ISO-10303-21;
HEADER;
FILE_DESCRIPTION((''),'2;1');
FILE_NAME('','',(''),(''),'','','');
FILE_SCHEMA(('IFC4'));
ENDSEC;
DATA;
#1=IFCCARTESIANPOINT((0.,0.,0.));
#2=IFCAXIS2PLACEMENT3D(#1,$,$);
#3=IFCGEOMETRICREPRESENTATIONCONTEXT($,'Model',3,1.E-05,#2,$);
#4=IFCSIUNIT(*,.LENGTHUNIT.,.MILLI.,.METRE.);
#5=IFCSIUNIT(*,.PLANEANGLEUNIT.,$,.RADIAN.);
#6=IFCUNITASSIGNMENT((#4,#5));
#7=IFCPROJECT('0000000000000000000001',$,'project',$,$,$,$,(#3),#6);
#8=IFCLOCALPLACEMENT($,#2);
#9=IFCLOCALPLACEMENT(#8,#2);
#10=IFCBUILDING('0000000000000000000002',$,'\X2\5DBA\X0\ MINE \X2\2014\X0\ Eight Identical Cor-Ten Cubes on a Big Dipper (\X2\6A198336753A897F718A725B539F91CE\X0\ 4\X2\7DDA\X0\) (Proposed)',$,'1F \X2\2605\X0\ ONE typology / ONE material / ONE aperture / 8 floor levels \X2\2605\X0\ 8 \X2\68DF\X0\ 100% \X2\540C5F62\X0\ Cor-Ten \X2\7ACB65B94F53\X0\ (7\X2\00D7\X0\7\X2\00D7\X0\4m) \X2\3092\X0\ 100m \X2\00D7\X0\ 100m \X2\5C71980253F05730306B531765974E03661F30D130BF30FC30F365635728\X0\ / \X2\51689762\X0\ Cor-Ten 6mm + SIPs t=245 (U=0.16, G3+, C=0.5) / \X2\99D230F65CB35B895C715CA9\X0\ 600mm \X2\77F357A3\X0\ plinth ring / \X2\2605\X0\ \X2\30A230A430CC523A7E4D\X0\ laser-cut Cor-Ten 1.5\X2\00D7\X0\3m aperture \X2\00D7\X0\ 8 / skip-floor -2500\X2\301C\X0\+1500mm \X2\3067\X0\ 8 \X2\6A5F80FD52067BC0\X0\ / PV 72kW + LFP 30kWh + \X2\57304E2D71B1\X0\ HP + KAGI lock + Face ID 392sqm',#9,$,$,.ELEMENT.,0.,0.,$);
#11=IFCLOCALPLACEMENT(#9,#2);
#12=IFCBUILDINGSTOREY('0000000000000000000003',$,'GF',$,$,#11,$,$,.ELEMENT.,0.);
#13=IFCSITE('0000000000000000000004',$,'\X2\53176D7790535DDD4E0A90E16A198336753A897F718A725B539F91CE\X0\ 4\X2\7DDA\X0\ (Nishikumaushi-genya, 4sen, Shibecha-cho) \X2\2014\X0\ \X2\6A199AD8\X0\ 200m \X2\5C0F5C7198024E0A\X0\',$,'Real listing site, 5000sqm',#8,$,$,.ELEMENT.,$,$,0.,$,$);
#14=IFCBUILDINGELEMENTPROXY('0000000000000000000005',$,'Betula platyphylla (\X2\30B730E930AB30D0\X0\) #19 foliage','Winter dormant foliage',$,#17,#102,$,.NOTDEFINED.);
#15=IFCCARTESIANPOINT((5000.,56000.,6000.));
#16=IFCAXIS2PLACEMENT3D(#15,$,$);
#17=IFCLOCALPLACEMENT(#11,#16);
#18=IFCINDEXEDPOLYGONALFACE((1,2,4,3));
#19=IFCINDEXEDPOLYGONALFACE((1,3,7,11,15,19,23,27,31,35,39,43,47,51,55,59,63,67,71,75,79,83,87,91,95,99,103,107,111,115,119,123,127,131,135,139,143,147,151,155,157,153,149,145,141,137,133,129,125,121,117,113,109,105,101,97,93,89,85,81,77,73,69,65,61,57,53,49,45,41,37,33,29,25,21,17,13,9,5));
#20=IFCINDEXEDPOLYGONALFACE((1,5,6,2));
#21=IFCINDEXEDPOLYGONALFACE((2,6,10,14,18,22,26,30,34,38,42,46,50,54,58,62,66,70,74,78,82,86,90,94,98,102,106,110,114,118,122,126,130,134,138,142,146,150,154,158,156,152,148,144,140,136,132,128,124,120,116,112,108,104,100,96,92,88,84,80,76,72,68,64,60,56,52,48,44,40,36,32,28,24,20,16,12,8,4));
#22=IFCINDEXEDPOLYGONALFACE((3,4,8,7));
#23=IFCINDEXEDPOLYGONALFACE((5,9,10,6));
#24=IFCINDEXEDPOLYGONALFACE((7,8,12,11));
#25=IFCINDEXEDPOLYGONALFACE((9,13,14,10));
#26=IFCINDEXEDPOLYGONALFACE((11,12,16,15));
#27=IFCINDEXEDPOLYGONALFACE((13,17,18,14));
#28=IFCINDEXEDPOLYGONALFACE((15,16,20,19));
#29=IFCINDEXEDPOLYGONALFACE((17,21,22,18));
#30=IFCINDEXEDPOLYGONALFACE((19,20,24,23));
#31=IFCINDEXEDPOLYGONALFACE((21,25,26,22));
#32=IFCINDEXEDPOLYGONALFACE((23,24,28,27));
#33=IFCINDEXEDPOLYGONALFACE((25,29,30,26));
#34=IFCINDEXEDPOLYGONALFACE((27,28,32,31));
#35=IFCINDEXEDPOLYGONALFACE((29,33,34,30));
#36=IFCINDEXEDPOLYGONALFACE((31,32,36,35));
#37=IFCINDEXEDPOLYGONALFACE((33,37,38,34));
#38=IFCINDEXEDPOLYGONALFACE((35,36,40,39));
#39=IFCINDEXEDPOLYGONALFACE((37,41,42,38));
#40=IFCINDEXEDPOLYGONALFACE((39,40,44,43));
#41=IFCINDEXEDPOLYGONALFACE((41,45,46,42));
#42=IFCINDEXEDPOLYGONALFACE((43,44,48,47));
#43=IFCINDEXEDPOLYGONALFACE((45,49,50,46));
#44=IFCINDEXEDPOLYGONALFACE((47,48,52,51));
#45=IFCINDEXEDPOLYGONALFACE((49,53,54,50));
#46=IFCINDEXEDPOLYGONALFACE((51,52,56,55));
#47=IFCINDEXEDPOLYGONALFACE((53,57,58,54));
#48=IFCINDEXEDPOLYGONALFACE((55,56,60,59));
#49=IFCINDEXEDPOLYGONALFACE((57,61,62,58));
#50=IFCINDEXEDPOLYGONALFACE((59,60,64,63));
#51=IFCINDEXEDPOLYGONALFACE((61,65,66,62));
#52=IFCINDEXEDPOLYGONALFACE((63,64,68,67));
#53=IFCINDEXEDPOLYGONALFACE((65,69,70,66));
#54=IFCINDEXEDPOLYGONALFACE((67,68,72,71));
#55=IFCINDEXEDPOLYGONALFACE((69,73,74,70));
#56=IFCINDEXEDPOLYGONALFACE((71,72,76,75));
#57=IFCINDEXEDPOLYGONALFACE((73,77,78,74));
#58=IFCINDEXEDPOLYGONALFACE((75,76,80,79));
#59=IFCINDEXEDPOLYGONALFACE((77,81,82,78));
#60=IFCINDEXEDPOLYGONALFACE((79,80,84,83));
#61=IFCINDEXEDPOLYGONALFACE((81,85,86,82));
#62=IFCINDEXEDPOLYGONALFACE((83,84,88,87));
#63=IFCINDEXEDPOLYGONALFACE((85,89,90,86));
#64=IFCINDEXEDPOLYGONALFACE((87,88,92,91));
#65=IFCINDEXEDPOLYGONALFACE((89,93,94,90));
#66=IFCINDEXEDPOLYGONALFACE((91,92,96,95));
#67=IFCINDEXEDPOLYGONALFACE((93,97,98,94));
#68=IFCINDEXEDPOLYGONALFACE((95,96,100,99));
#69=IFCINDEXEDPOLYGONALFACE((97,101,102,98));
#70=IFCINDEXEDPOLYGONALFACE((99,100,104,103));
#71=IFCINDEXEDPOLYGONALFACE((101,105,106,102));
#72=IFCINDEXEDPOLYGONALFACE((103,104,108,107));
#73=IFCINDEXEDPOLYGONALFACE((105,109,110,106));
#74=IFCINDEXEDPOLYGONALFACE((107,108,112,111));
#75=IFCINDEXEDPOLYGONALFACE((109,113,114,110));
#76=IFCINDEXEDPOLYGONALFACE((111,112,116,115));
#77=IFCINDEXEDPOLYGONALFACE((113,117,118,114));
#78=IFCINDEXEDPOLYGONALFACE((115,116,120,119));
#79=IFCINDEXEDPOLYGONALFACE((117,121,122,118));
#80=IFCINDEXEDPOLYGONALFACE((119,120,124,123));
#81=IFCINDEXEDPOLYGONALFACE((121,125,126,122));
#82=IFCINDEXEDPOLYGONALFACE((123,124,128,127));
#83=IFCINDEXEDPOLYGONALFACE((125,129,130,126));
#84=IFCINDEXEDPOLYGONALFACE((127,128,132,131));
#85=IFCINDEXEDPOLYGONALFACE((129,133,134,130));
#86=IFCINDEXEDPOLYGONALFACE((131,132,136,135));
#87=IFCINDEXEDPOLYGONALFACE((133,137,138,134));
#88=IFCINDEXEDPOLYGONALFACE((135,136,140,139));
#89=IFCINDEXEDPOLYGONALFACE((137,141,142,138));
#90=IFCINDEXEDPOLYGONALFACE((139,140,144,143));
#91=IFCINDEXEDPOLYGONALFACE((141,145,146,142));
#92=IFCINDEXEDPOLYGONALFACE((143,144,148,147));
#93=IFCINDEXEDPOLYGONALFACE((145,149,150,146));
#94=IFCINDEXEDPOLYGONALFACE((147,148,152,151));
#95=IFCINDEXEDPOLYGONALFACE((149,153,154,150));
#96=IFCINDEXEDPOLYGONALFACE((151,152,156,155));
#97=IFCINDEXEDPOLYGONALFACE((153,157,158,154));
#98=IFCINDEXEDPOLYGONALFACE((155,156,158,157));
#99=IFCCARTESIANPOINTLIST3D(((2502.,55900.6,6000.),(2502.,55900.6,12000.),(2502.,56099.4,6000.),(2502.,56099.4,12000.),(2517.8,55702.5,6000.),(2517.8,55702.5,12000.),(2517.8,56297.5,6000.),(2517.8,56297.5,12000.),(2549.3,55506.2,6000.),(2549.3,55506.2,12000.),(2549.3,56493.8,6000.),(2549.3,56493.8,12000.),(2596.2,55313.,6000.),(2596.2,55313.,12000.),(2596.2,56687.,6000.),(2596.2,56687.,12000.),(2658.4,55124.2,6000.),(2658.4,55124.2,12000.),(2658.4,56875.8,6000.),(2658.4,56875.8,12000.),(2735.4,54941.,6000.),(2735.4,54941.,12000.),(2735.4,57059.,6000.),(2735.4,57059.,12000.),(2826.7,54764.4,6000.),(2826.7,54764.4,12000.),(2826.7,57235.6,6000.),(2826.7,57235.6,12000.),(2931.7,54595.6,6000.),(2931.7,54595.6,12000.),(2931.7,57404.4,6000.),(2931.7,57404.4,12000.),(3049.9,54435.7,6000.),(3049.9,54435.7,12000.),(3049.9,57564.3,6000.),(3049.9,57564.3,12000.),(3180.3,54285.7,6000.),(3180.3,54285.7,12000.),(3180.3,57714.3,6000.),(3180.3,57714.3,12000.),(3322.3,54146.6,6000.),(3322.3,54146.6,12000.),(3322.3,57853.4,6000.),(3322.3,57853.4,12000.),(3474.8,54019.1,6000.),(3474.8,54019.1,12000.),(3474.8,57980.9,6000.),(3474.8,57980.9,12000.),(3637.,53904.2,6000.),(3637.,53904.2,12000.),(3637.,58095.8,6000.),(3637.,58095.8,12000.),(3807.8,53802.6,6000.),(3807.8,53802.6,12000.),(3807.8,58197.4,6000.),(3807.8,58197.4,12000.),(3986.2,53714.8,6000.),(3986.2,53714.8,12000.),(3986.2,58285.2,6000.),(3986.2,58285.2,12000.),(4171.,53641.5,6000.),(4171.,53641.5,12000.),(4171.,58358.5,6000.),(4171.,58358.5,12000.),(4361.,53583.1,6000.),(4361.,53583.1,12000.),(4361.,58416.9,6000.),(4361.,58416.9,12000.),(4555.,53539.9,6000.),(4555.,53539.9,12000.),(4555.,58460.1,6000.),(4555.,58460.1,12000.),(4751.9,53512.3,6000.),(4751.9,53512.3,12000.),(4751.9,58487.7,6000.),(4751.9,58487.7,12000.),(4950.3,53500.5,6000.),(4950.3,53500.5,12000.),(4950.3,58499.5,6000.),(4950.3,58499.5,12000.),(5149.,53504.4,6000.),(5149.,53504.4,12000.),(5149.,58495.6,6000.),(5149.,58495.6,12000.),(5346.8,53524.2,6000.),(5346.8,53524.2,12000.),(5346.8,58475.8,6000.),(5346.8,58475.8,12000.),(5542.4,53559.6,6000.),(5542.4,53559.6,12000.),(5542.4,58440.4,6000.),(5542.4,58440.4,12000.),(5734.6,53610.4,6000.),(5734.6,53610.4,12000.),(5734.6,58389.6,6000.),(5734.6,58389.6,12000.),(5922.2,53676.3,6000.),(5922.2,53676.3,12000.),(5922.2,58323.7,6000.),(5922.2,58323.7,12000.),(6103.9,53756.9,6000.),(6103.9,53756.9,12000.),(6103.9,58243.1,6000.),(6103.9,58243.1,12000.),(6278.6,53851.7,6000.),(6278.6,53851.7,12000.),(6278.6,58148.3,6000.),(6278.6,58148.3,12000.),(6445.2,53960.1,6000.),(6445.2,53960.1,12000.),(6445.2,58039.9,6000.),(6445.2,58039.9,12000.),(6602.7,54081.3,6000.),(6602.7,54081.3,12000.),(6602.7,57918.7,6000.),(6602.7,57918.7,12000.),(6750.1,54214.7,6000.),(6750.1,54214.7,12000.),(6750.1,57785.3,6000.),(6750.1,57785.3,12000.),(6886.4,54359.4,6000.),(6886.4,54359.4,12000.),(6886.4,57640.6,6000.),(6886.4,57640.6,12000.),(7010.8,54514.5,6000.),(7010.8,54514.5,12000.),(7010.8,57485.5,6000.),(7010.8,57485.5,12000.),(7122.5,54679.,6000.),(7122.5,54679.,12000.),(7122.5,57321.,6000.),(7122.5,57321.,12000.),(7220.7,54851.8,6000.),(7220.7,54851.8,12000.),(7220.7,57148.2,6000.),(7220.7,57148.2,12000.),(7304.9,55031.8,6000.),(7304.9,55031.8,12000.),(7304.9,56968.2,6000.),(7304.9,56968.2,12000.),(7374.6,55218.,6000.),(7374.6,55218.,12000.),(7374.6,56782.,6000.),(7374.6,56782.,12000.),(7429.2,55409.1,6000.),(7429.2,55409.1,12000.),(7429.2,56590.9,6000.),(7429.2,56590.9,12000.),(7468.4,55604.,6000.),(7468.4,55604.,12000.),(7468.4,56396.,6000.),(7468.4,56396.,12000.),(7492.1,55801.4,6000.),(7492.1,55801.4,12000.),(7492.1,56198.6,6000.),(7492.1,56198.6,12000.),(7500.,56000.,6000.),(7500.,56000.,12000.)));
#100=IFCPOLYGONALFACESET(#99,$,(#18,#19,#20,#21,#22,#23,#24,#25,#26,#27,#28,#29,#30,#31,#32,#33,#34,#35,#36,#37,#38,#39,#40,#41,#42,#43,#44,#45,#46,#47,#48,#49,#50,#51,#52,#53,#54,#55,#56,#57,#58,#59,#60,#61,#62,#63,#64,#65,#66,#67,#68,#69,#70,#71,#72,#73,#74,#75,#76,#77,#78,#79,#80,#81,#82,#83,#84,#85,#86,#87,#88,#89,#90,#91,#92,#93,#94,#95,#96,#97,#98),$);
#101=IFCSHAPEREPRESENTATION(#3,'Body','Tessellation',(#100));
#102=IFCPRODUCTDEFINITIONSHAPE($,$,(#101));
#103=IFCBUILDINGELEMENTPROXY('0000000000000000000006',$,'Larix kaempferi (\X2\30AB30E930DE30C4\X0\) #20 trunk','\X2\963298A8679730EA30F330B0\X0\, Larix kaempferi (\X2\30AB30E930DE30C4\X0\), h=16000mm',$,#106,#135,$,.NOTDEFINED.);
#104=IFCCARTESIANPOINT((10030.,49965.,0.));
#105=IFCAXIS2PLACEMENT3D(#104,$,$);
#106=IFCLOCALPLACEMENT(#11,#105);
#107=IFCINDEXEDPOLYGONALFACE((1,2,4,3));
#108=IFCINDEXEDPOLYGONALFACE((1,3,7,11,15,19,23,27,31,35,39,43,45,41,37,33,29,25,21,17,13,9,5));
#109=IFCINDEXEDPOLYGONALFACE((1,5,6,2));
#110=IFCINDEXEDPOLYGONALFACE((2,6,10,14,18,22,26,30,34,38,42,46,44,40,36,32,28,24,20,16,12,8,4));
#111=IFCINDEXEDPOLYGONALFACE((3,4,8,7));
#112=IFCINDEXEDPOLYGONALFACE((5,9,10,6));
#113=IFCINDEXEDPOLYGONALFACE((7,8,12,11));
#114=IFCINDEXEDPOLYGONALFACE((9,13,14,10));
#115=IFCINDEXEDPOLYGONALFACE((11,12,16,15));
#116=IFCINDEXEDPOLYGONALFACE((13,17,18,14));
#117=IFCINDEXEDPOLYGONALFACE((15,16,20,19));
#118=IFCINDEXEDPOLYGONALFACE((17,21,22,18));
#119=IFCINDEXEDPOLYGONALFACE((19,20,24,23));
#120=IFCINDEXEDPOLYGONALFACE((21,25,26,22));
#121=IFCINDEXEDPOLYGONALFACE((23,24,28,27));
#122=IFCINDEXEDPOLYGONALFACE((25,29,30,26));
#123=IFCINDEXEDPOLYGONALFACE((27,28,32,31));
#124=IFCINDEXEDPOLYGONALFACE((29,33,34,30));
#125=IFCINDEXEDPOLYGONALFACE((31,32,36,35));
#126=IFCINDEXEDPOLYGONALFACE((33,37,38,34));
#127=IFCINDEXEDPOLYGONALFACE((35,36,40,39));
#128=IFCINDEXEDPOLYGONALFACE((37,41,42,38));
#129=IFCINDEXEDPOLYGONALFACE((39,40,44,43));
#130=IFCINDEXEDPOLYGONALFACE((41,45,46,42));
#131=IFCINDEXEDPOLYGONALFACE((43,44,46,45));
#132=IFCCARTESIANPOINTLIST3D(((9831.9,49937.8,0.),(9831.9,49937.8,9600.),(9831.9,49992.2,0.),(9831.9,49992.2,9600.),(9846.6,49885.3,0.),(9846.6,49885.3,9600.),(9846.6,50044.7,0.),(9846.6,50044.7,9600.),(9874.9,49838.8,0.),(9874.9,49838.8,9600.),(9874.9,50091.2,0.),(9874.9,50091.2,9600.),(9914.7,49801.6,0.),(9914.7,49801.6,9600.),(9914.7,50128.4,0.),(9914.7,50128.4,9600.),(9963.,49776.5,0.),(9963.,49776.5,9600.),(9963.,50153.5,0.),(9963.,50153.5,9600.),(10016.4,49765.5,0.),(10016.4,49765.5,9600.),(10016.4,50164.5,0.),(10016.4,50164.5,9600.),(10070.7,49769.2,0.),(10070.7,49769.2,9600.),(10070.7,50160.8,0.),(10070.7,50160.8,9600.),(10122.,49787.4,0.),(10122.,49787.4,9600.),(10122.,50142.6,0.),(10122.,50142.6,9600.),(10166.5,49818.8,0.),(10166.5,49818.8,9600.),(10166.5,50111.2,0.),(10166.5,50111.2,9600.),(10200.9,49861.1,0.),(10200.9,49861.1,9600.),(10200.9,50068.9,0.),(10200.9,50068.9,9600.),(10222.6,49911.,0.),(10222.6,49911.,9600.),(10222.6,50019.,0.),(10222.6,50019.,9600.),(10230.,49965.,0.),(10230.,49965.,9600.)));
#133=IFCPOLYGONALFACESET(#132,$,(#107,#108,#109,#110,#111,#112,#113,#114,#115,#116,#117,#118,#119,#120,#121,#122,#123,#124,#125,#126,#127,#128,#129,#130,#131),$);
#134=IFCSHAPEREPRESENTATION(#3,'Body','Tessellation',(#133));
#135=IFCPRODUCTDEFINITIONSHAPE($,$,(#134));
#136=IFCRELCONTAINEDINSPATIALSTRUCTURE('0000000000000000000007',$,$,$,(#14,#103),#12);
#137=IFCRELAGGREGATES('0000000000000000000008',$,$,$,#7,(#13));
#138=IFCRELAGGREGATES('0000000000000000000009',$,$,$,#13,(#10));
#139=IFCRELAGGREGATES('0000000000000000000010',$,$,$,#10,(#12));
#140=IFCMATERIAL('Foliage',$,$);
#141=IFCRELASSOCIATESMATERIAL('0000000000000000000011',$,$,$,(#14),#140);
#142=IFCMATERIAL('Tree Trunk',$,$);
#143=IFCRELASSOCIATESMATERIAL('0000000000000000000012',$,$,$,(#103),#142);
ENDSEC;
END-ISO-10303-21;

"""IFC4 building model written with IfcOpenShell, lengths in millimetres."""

from ifc_helpers import new_model, si_unit, frame, origin, origin_2d, place, context, project, spatial, circle, extrude, material, element, save


model = new_model("IFC4")

# Units and contexts
model_context = context("Model", 3, precision=1e-05, world=origin())
ifc_project = project(units=[si_unit("LENGTHUNIT", "METRE", prefix="MILLI"), si_unit("PLANEANGLEUNIT", "RADIAN")], contexts=[model_context])

# Site, building, storey
site_placement = place(None, origin())
site = spatial("IfcSite", under=ifc_project, at=site_placement, Name="北海道川上郡標茶町西熊牛原野 4線 (Nishikumaushi-genya, 4sen, Shibecha-cho) — 標高 200m 小山頂上", ObjectType="Real listing site, 5000sqm", CompositionType="ELEMENT", RefElevation=0.0)
building_placement = place(site_placement, origin())
building = spatial("IfcBuilding", under=site, at=building_placement, Name="嶺 MINE — Eight Identical Cor-Ten Cubes on a Big Dipper (標茶町西熊牛原野 4線) (Proposed)", ObjectType="1F ★ ONE typology / ONE material / ONE aperture / 8 floor levels ★ 8 棟 100% 同形 Cor-Ten 立方体 (7×7×4m) を 100m × 100m 山頂台地に北斗七星パターン散在 / 全面 Cor-Ten 6mm + SIPs t=245 (U=0.16, G3+, C=0.5) / 駒ヶ岳安山岩 600mm 石垣 plinth ring / ★ アイヌ刺繍 laser-cut Cor-Ten 1.5×3m aperture × 8 / skip-floor -2500〜+1500mm で 8 機能分節 / PV 72kW + LFP 30kWh + 地中熱 HP + KAGI lock + Face ID 392sqm", CompositionType="ELEMENT", ElevationOfRefHeight=0.0, ElevationOfTerrain=0.0)
storey_placement = place(building_placement, origin())
storey = spatial("IfcBuildingStorey", under=building, at=storey_placement, Name="GF", CompositionType="ELEMENT", Elevation=0.0)

# Building element proxies
ifc_material_1 = material(Name="Tree Trunk")
ifc_material_2 = material(Name="Foliage")
proxy_1_placement = place(storey_placement, frame((5000.0, 56000.0, 6000.0)))
element("IfcBuildingElementProxy", 1, at=proxy_1_placement, inside=storey, material=ifc_material_2, Name="Betula platyphylla (シラカバ) #19 foliage", Description="Winter dormant foliage", PredefinedType="NOTDEFINED", context=model_context, shape_type="SweptSolid", body=[
    extrude(circle(Radius=2500.0, at=origin_2d()), frame((5000.0, 56000.0, 6000.0)), (0.0, 0.0, 1.0), 6000.0),
])
proxy_2_placement = place(storey_placement, frame((10030.0, 49965.0, 0.0)))
element("IfcBuildingElementProxy", 2, at=proxy_2_placement, inside=storey, material=ifc_material_1, Name="Larix kaempferi (カラマツ) #20 trunk", Description="防風林リング, Larix kaempferi (カラマツ), h=16000mm", PredefinedType="NOTDEFINED", context=model_context, shape_type="SweptSolid", body=[
    extrude(circle(Radius=200.0, at=origin_2d()), frame((10030.0, 49965.0, 0.0)), (0.0, 0.0, 1.0), 9600.0),
])

save(model, "model.ifc")
